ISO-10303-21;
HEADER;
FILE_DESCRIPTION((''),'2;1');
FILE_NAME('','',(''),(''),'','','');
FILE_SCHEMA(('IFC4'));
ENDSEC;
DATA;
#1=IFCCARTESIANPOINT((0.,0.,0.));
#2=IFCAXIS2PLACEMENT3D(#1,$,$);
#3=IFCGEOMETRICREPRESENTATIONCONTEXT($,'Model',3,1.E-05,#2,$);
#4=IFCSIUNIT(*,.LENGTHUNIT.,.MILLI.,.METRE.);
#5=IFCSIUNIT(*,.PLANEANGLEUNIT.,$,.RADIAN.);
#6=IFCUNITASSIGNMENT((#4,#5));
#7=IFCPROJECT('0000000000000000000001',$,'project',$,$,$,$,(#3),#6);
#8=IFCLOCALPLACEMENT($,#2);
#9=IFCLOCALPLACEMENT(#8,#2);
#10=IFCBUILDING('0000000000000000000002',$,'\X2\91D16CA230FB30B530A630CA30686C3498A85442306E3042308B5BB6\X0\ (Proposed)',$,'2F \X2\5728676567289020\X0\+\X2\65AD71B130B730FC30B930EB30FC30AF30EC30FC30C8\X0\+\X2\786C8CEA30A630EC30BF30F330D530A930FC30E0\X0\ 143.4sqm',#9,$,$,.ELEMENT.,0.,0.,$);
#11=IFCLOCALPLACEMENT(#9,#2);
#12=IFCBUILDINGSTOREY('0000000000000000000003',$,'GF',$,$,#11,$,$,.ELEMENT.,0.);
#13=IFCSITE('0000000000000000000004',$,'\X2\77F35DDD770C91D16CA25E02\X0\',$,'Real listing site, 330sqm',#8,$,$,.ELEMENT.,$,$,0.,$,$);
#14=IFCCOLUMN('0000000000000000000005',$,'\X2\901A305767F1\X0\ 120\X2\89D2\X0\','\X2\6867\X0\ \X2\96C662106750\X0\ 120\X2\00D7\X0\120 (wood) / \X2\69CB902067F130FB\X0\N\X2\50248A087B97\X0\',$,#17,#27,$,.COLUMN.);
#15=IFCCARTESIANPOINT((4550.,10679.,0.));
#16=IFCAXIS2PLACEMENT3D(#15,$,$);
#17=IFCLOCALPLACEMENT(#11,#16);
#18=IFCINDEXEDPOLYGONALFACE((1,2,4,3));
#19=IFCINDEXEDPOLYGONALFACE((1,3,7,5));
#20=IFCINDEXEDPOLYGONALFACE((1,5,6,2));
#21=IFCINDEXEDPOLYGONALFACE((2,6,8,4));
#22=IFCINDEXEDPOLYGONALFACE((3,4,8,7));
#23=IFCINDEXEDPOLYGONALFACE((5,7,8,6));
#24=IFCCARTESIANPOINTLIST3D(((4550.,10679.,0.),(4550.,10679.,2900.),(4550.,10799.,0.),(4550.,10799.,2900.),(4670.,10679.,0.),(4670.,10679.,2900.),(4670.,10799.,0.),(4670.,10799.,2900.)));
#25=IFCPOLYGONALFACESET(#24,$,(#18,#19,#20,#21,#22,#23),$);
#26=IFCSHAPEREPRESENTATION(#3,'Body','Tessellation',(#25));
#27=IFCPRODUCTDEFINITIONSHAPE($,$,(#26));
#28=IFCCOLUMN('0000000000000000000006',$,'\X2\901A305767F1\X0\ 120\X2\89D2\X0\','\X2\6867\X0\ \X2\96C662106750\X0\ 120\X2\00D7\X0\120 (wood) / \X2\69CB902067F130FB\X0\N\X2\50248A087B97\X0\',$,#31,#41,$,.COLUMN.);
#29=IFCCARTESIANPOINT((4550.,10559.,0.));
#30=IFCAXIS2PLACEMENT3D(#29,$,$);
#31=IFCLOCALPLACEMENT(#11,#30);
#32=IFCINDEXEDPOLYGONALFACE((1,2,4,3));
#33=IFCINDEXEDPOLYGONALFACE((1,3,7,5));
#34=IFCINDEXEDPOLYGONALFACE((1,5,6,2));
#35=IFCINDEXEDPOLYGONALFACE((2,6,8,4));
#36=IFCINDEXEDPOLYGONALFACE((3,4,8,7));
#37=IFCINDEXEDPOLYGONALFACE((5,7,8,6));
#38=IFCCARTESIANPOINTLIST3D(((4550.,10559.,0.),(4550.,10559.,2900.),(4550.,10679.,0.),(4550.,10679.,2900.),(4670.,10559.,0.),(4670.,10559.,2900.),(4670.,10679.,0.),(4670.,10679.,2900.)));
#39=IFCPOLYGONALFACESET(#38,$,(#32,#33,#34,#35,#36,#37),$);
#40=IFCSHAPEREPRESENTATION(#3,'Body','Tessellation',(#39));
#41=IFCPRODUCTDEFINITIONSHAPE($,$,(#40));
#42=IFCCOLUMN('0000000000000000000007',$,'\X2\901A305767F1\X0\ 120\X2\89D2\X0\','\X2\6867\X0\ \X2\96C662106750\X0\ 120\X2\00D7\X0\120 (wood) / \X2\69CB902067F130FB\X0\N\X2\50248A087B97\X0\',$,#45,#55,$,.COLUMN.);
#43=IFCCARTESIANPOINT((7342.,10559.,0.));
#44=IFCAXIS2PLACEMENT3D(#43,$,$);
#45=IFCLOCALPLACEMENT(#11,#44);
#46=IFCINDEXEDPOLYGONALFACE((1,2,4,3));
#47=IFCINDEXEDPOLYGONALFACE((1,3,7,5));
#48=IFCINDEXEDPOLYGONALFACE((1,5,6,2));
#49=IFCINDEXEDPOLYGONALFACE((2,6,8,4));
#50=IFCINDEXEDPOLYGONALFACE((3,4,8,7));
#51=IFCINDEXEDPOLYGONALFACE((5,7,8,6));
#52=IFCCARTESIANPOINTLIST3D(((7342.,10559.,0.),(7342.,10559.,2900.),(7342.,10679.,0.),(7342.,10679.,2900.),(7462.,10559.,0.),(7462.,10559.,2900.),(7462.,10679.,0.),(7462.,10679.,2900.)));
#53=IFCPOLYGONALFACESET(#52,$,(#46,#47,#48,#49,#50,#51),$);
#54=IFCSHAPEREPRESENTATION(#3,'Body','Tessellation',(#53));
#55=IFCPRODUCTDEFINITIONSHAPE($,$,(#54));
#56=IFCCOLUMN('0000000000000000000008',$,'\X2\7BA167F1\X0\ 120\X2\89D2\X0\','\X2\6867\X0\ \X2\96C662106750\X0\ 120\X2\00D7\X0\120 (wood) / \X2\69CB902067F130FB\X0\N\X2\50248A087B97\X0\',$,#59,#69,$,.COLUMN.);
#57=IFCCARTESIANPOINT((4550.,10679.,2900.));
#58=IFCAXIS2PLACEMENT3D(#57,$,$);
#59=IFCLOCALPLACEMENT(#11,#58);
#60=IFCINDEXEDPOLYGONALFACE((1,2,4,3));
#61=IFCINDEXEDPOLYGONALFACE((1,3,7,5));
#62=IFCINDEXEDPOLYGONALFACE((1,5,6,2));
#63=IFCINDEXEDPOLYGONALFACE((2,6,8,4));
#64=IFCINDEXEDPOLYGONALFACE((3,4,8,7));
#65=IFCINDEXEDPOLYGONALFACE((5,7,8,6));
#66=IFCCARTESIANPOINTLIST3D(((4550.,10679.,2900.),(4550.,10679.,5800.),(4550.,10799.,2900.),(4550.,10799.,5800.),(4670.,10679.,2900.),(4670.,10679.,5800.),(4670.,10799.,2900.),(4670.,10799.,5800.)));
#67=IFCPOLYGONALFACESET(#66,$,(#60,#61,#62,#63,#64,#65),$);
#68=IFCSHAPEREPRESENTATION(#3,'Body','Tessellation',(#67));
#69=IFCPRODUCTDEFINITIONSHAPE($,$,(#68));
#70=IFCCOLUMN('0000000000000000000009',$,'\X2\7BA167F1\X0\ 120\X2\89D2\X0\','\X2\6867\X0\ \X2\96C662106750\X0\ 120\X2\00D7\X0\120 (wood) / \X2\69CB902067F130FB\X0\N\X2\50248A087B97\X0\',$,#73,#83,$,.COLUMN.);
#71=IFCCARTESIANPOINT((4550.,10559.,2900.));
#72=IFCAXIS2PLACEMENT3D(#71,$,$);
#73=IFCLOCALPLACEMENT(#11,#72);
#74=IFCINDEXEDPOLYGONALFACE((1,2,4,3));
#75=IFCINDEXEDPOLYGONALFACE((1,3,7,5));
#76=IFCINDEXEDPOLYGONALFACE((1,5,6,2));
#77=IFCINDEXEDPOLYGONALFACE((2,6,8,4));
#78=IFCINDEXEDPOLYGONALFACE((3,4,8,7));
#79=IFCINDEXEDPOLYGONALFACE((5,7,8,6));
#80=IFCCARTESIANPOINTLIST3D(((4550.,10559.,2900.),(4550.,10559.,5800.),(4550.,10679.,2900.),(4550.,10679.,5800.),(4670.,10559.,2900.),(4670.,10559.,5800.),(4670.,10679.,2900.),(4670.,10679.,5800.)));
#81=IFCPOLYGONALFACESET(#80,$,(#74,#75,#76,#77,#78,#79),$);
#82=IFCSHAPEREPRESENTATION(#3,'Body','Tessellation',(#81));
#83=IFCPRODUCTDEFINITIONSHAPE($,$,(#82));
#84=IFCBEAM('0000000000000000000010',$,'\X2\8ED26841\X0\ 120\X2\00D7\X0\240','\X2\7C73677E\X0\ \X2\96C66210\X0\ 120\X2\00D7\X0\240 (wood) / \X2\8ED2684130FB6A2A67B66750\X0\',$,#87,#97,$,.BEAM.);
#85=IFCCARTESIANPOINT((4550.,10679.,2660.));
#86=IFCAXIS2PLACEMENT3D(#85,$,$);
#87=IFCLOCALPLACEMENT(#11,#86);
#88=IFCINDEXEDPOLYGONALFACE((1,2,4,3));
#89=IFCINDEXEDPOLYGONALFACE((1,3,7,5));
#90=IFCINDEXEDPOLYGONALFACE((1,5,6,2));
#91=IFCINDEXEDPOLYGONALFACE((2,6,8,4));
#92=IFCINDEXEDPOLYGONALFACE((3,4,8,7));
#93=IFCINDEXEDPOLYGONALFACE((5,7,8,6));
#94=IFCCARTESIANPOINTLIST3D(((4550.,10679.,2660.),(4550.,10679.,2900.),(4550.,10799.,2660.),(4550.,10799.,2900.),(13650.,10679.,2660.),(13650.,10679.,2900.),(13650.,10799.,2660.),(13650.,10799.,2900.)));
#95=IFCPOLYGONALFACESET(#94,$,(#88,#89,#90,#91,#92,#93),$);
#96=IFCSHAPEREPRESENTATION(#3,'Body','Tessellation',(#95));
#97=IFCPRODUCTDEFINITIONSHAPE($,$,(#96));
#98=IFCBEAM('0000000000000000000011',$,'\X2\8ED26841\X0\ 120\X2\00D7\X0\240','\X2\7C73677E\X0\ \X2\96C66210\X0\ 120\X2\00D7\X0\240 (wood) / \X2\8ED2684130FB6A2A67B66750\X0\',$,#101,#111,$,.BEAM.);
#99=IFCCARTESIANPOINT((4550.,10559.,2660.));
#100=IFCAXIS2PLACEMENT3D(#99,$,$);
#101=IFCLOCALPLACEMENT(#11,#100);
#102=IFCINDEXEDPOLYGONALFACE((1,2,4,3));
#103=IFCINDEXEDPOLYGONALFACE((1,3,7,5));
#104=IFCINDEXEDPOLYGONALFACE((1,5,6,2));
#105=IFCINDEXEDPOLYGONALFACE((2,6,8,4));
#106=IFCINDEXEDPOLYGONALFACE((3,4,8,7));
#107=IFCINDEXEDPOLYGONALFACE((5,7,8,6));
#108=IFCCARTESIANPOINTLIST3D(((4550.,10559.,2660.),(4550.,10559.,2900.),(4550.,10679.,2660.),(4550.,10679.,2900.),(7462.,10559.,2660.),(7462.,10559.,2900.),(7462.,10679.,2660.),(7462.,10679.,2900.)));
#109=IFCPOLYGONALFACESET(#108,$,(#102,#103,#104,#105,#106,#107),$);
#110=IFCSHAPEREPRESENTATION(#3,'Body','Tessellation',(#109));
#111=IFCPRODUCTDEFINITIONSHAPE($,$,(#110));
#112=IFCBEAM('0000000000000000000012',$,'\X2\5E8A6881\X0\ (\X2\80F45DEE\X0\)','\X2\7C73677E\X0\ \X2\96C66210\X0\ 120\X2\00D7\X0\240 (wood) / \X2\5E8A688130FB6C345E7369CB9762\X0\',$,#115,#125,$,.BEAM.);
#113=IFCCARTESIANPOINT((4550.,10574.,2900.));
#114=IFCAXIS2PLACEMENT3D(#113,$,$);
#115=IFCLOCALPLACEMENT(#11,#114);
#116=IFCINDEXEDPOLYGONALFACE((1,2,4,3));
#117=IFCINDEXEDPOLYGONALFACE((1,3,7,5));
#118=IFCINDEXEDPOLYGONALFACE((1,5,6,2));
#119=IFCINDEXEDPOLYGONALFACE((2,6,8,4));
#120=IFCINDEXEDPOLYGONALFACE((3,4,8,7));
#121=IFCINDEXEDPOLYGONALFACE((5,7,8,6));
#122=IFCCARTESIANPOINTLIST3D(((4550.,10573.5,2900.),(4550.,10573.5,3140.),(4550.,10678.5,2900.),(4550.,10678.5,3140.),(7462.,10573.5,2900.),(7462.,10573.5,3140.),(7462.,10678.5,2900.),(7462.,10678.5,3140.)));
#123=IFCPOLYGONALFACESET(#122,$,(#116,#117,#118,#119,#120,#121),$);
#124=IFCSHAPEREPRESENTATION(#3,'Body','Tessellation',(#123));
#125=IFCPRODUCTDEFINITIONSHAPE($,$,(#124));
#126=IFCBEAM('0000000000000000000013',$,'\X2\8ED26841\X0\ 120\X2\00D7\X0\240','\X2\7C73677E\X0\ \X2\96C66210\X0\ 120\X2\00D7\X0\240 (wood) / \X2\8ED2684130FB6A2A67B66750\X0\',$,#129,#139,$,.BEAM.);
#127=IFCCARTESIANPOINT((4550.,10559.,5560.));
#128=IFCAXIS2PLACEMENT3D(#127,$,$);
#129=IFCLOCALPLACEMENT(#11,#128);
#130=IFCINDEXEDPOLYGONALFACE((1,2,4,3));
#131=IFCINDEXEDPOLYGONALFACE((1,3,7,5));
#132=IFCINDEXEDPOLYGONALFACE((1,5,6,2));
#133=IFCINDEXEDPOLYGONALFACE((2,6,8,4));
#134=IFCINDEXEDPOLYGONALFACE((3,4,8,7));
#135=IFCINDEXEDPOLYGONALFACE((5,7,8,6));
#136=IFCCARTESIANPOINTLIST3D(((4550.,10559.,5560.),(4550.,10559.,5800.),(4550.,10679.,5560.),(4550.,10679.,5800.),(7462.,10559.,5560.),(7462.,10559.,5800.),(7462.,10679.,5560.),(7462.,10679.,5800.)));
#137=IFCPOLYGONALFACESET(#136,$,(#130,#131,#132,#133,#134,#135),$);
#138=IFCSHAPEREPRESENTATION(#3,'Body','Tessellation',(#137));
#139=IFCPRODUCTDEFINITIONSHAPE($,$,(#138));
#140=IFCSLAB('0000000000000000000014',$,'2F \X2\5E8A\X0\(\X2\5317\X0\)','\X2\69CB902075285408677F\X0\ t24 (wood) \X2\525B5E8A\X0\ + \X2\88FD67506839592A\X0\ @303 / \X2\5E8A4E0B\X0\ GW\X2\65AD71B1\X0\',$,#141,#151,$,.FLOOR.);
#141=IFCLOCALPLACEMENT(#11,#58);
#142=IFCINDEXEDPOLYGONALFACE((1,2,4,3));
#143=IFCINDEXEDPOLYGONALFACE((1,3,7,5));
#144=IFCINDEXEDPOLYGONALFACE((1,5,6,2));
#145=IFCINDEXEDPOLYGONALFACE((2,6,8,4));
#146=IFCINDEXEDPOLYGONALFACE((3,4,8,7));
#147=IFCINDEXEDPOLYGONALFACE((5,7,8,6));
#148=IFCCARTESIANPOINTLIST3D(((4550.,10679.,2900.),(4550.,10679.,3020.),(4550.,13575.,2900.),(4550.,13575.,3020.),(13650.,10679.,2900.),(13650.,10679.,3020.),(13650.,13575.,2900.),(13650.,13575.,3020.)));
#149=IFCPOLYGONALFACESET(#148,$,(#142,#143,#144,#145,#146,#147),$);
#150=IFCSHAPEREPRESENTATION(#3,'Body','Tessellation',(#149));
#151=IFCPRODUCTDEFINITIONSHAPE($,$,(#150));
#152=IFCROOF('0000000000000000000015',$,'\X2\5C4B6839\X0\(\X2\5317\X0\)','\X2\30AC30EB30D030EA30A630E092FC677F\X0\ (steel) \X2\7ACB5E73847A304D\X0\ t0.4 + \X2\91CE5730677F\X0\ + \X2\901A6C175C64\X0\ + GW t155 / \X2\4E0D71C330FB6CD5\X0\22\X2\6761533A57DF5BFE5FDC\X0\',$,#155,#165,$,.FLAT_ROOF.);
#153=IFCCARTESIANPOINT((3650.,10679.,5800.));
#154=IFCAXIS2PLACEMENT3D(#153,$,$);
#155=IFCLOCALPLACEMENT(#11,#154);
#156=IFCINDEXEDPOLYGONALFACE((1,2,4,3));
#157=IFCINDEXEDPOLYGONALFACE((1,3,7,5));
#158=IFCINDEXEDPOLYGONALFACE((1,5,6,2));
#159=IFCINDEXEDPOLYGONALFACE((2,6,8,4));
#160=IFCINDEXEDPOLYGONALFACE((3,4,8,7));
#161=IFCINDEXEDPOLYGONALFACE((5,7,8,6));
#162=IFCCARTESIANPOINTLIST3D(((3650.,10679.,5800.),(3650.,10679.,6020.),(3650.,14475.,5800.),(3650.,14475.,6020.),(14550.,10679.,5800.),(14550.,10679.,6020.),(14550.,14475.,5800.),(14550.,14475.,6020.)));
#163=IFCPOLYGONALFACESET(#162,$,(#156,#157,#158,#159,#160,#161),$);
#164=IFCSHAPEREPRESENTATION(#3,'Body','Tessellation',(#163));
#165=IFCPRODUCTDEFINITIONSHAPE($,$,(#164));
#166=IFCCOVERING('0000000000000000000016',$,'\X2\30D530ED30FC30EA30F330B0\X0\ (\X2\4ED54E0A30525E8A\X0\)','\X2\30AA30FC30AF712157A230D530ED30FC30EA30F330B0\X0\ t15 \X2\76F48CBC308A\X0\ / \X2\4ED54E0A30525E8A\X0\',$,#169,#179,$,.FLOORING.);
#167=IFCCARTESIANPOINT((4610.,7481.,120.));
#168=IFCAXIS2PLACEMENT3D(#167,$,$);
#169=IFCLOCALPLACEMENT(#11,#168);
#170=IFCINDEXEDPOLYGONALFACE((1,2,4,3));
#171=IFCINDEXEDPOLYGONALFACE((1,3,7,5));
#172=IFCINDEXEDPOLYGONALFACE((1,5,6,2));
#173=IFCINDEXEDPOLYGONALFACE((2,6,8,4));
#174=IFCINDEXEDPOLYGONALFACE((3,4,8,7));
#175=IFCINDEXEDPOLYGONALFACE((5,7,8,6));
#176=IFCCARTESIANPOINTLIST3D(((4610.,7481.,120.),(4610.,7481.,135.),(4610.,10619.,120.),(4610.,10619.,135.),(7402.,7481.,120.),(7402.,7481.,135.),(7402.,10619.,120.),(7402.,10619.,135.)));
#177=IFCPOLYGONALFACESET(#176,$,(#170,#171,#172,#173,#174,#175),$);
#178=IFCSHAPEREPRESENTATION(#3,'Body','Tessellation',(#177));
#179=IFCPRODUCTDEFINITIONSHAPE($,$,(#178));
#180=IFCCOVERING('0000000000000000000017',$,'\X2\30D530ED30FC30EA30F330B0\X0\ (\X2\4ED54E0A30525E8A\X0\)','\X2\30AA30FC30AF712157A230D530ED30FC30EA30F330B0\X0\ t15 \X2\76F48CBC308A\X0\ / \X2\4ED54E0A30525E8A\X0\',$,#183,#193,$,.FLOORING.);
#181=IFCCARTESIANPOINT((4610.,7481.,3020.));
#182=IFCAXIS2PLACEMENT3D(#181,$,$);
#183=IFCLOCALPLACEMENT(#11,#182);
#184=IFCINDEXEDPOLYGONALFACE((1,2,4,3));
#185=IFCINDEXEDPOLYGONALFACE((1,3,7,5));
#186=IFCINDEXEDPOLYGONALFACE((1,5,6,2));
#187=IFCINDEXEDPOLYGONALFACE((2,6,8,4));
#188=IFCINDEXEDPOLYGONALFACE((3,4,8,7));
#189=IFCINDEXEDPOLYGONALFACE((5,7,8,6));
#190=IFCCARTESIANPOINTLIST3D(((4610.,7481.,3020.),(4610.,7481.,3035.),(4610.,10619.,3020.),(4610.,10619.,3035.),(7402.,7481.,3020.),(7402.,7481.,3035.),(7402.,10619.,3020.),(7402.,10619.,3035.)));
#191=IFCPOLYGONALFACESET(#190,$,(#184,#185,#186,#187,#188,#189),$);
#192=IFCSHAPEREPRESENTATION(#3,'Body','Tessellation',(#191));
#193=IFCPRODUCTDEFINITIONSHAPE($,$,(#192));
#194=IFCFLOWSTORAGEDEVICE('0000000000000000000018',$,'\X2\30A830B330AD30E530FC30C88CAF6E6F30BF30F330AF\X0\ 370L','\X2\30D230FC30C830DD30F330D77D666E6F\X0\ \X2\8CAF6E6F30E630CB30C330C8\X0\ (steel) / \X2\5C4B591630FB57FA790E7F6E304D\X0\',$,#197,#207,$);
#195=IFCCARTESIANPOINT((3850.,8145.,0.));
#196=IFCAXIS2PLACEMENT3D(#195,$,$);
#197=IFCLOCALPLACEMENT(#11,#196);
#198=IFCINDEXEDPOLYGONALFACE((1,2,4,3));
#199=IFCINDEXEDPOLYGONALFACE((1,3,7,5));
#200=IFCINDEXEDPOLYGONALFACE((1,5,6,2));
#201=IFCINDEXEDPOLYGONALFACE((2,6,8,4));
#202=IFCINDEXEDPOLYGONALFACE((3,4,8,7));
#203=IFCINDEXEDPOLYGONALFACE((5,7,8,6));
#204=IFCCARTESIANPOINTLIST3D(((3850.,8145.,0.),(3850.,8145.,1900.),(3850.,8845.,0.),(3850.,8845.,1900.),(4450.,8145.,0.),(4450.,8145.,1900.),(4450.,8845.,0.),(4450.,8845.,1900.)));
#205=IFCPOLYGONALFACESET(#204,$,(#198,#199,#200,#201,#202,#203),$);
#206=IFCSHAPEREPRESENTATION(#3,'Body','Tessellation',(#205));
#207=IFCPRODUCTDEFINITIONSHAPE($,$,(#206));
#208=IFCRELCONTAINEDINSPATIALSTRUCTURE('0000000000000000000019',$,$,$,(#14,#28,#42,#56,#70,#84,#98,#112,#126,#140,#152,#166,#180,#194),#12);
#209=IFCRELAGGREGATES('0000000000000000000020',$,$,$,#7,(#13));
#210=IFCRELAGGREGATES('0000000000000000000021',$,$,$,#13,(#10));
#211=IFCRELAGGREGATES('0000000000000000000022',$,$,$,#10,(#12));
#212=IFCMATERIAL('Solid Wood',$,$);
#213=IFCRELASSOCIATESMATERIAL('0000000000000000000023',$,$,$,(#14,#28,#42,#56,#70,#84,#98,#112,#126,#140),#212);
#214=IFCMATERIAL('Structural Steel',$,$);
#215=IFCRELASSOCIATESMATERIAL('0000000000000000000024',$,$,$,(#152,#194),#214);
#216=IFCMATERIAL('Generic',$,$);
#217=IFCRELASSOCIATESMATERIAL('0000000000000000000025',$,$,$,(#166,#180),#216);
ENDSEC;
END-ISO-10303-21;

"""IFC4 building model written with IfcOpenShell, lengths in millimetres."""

from ifc_helpers import new_model, si_unit, frame, frame_2d, origin, place, context, project, spatial, rectangle, extrude, material, element, save


model = new_model("IFC4")

# Units and contexts
model_context = context("Model", 3, precision=1e-05, world=origin())
ifc_project = project(units=[si_unit("LENGTHUNIT", "METRE", prefix="MILLI"), si_unit("PLANEANGLEUNIT", "RADIAN")], contexts=[model_context])

# Site, building, storey
site_placement = place(None, origin())
site = spatial("IfcSite", under=ifc_project, at=site_placement, Name="石川県金沢市", ObjectType="Real listing site, 330sqm", CompositionType="ELEMENT", RefElevation=0.0)
building_placement = place(site_placement, origin())
building = spatial("IfcBuilding", under=site, at=building_placement, Name="金沢・サウナと水風呂のある家 (Proposed)", ObjectType="2F 在来木造+断熱シースルークレート+硬質ウレタンフォーム 143.4sqm", CompositionType="ELEMENT", ElevationOfRefHeight=0.0, ElevationOfTerrain=0.0)
storey_placement = place(building_placement, origin())
storey = spatial("IfcBuildingStorey", under=building, at=storey_placement, Name="GF", CompositionType="ELEMENT", Elevation=0.0)

# Columns
ifc_material_1 = material(Name="Solid Wood")
column_1_placement = place(storey_placement, frame((4550.0, 10679.0, 0.0)))
element("IfcColumn", 1, at=column_1_placement, inside=storey, material=ifc_material_1, Name="通し柱 120角", Description="桧 集成材 120×120 (wood) / 構造柱・N値計算", PredefinedType="COLUMN", context=model_context, shape_type="SweptSolid", body=[
    extrude(rectangle(XDim=120.0, YDim=120.0, at=frame_2d((60.0, 60.0))), frame((4550.0, 10679.0, 0.0)), (0.0, 0.0, 1.0), 2900.0),
])
column_2_placement = place(storey_placement, frame((4550.0, 10559.0, 0.0)))
element("IfcColumn", 2, at=column_2_placement, inside=storey, material=ifc_material_1, Name="通し柱 120角", Description="桧 集成材 120×120 (wood) / 構造柱・N値計算", PredefinedType="COLUMN", context=model_context, shape_type="SweptSolid", body=[
    extrude(rectangle(XDim=120.0, YDim=120.0, at=frame_2d((60.0, 60.0))), frame((4550.0, 10559.0, 0.0)), (0.0, 0.0, 1.0), 2900.0),
])
column_3_placement = place(storey_placement, frame((7342.0, 10559.0, 0.0)))
element("IfcColumn", 3, at=column_3_placement, inside=storey, material=ifc_material_1, Name="通し柱 120角", Description="桧 集成材 120×120 (wood) / 構造柱・N値計算", PredefinedType="COLUMN", context=model_context, shape_type="SweptSolid", body=[
    extrude(rectangle(XDim=120.0, YDim=120.0, at=frame_2d((60.0, 60.0))), frame((7342.0, 10559.0, 0.0)), (0.0, 0.0, 1.0), 2900.0),
])
column_4_placement = place(storey_placement, frame((4550.0, 10679.0, 2900.0)))
element("IfcColumn", 4, at=column_4_placement, inside=storey, material=ifc_material_1, Name="管柱 120角", Description="桧 集成材 120×120 (wood) / 構造柱・N値計算", PredefinedType="COLUMN", context=model_context, shape_type="SweptSolid", body=[
    extrude(rectangle(XDim=120.0, YDim=120.0, at=frame_2d((60.0, 60.0))), frame((4550.0, 10679.0, 2900.0)), (0.0, 0.0, 1.0), 2900.0),
])
column_5_placement = place(storey_placement, frame((4550.0, 10559.0, 2900.0)))
element("IfcColumn", 5, at=column_5_placement, inside=storey, material=ifc_material_1, Name="管柱 120角", Description="桧 集成材 120×120 (wood) / 構造柱・N値計算", PredefinedType="COLUMN", context=model_context, shape_type="SweptSolid", body=[
    extrude(rectangle(XDim=120.0, YDim=120.0, at=frame_2d((60.0, 60.0))), frame((4550.0, 10559.0, 2900.0)), (0.0, 0.0, 1.0), 2900.0),
])

# Beams
beam_1_placement = place(storey_placement, frame((4550.0, 10679.0, 2660.0)))
element("IfcBeam", 6, at=beam_1_placement, inside=storey, material=ifc_material_1, Name="軒桁 120×240", Description="米松 集成 120×240 (wood) / 軒桁・横架材", PredefinedType="BEAM", context=model_context, shape_type="SweptSolid", body=[
    extrude(rectangle(XDim=9100.0, YDim=120.0, at=frame_2d((4550.0, 60.0))), frame((4550.0, 10679.0, 2660.0)), (0.0, 0.0, 1.0), 240.0),
])
beam_2_placement = place(storey_placement, frame((4550.0, 10559.0, 2660.0)))
element("IfcBeam", 7, at=beam_2_placement, inside=storey, material=ifc_material_1, Name="軒桁 120×240", Description="米松 集成 120×240 (wood) / 軒桁・横架材", PredefinedType="BEAM", context=model_context, shape_type="SweptSolid", body=[
    extrude(rectangle(XDim=2912.0, YDim=120.0, at=frame_2d((1456.0, 60.0))), frame((4550.0, 10559.0, 2660.0)), (0.0, 0.0, 1.0), 240.0),
])
beam_3_placement = place(storey_placement, frame((4550.0, 10574.0, 2900.0)))
element("IfcBeam", 8, at=beam_3_placement, inside=storey, material=ifc_material_1, Name="床梁 (胴差)", Description="米松 集成 120×240 (wood) / 床梁・水平構面", PredefinedType="BEAM", context=model_context, shape_type="SweptSolid", body=[
    extrude(rectangle(XDim=2912.0, YDim=105.0, at=frame_2d((1456.0, 52.0))), frame((4550.0, 10574.0, 2900.0)), (0.0, 0.0, 1.0), 240.0),
])
beam_4_placement = place(storey_placement, frame((4550.0, 10559.0, 5560.0)))
element("IfcBeam", 9, at=beam_4_placement, inside=storey, material=ifc_material_1, Name="軒桁 120×240", Description="米松 集成 120×240 (wood) / 軒桁・横架材", PredefinedType="BEAM", context=model_context, shape_type="SweptSolid", body=[
    extrude(rectangle(XDim=2912.0, YDim=120.0, at=frame_2d((1456.0, 60.0))), frame((4550.0, 10559.0, 5560.0)), (0.0, 0.0, 1.0), 240.0),
])

# Slab
slab_1_placement = place(storey_placement, frame((4550.0, 10679.0, 2900.0)))
element("IfcSlab", 10, at=slab_1_placement, inside=storey, material=ifc_material_1, Name="2F 床(北)", Description="構造用合板 t24 (wood) 剛床 + 製材根太 @303 / 床下 GW断熱", PredefinedType="FLOOR", context=model_context, shape_type="SweptSolid", body=[
    extrude(rectangle(XDim=9100.0, YDim=2896.0, at=frame_2d((4550.0, 1448.0))), frame((4550.0, 10679.0, 2900.0)), (0.0, 0.0, 1.0), 120.0),
])

# Roof
ifc_material_2 = material(Name="Structural Steel")
for number, where, name in (
    (11, (3650.0, 10679.0, 5800.0), "屋根(北)"),
):
    element("IfcRoof", number, at=place(storey_placement, frame(where)), inside=storey, material=ifc_material_2, Name=name, Description="ガルバリウム鋼板 (steel) 立平葺き t0.4 + 野地板 + 通気層 + GW t155 / 不燃・法22条区域対応", PredefinedType="FLAT_ROOF", context=model_context, shape_type="SweptSolid", body=[
        extrude(rectangle(XDim=10900.0, YDim=3796.0, at=frame_2d((5450.0, 1898.0))), frame((3650.0, 10679.0, 5800.0)), (0.0, 0.0, 1.0), 220.0),
    ])

# Coverings
ifc_material_3 = material(Name="Generic")
covering_1_placement = place(storey_placement, frame((4610.0, 7481.0, 120.0)))
element("IfcCovering", 12, at=covering_1_placement, inside=storey, material=ifc_material_3, Name="フローリング (仕上げ床)", Description="オーク無垢フローリング t15 直貼り / 仕上げ床", PredefinedType="FLOORING", context=model_context, shape_type="SweptSolid", body=[
    extrude(rectangle(XDim=2792.0, YDim=3138.0, at=frame_2d((1396.0, 1569.0))), frame((4610.0, 7481.0, 120.0)), (0.0, 0.0, 1.0), 15.0),
])
covering_2_placement = place(storey_placement, frame((4610.0, 7481.0, 3020.0)))
element("IfcCovering", 13, at=covering_2_placement, inside=storey, material=ifc_material_3, Name="フローリング (仕上げ床)", Description="オーク無垢フローリング t15 直貼り / 仕上げ床", PredefinedType="FLOORING", context=model_context, shape_type="SweptSolid", body=[
    extrude(rectangle(XDim=2792.0, YDim=3138.0, at=frame_2d((1396.0, 1569.0))), frame((4610.0, 7481.0, 3020.0)), (0.0, 0.0, 1.0), 15.0),
])

# Flow storage device
flow_storage_device_placement = place(storey_placement, frame((3850.0, 8145.0, 0.0)))
element("IfcFlowStorageDevice", 14, at=flow_storage_device_placement, inside=storey, material=ifc_material_2, Name="エコキュート貯湯タンク 370L", Description="ヒートポンプ給湯 貯湯ユニット (steel) / 屋外・基礎置き", context=model_context, shape_type="SweptSolid", body=[
    extrude(rectangle(XDim=600.0, YDim=700.0, at=frame_2d((300.0, 350.0))), frame((3850.0, 8145.0, 0.0)), (0.0, 0.0, 1.0), 1900.0),
])

save(model, "model.ifc")
